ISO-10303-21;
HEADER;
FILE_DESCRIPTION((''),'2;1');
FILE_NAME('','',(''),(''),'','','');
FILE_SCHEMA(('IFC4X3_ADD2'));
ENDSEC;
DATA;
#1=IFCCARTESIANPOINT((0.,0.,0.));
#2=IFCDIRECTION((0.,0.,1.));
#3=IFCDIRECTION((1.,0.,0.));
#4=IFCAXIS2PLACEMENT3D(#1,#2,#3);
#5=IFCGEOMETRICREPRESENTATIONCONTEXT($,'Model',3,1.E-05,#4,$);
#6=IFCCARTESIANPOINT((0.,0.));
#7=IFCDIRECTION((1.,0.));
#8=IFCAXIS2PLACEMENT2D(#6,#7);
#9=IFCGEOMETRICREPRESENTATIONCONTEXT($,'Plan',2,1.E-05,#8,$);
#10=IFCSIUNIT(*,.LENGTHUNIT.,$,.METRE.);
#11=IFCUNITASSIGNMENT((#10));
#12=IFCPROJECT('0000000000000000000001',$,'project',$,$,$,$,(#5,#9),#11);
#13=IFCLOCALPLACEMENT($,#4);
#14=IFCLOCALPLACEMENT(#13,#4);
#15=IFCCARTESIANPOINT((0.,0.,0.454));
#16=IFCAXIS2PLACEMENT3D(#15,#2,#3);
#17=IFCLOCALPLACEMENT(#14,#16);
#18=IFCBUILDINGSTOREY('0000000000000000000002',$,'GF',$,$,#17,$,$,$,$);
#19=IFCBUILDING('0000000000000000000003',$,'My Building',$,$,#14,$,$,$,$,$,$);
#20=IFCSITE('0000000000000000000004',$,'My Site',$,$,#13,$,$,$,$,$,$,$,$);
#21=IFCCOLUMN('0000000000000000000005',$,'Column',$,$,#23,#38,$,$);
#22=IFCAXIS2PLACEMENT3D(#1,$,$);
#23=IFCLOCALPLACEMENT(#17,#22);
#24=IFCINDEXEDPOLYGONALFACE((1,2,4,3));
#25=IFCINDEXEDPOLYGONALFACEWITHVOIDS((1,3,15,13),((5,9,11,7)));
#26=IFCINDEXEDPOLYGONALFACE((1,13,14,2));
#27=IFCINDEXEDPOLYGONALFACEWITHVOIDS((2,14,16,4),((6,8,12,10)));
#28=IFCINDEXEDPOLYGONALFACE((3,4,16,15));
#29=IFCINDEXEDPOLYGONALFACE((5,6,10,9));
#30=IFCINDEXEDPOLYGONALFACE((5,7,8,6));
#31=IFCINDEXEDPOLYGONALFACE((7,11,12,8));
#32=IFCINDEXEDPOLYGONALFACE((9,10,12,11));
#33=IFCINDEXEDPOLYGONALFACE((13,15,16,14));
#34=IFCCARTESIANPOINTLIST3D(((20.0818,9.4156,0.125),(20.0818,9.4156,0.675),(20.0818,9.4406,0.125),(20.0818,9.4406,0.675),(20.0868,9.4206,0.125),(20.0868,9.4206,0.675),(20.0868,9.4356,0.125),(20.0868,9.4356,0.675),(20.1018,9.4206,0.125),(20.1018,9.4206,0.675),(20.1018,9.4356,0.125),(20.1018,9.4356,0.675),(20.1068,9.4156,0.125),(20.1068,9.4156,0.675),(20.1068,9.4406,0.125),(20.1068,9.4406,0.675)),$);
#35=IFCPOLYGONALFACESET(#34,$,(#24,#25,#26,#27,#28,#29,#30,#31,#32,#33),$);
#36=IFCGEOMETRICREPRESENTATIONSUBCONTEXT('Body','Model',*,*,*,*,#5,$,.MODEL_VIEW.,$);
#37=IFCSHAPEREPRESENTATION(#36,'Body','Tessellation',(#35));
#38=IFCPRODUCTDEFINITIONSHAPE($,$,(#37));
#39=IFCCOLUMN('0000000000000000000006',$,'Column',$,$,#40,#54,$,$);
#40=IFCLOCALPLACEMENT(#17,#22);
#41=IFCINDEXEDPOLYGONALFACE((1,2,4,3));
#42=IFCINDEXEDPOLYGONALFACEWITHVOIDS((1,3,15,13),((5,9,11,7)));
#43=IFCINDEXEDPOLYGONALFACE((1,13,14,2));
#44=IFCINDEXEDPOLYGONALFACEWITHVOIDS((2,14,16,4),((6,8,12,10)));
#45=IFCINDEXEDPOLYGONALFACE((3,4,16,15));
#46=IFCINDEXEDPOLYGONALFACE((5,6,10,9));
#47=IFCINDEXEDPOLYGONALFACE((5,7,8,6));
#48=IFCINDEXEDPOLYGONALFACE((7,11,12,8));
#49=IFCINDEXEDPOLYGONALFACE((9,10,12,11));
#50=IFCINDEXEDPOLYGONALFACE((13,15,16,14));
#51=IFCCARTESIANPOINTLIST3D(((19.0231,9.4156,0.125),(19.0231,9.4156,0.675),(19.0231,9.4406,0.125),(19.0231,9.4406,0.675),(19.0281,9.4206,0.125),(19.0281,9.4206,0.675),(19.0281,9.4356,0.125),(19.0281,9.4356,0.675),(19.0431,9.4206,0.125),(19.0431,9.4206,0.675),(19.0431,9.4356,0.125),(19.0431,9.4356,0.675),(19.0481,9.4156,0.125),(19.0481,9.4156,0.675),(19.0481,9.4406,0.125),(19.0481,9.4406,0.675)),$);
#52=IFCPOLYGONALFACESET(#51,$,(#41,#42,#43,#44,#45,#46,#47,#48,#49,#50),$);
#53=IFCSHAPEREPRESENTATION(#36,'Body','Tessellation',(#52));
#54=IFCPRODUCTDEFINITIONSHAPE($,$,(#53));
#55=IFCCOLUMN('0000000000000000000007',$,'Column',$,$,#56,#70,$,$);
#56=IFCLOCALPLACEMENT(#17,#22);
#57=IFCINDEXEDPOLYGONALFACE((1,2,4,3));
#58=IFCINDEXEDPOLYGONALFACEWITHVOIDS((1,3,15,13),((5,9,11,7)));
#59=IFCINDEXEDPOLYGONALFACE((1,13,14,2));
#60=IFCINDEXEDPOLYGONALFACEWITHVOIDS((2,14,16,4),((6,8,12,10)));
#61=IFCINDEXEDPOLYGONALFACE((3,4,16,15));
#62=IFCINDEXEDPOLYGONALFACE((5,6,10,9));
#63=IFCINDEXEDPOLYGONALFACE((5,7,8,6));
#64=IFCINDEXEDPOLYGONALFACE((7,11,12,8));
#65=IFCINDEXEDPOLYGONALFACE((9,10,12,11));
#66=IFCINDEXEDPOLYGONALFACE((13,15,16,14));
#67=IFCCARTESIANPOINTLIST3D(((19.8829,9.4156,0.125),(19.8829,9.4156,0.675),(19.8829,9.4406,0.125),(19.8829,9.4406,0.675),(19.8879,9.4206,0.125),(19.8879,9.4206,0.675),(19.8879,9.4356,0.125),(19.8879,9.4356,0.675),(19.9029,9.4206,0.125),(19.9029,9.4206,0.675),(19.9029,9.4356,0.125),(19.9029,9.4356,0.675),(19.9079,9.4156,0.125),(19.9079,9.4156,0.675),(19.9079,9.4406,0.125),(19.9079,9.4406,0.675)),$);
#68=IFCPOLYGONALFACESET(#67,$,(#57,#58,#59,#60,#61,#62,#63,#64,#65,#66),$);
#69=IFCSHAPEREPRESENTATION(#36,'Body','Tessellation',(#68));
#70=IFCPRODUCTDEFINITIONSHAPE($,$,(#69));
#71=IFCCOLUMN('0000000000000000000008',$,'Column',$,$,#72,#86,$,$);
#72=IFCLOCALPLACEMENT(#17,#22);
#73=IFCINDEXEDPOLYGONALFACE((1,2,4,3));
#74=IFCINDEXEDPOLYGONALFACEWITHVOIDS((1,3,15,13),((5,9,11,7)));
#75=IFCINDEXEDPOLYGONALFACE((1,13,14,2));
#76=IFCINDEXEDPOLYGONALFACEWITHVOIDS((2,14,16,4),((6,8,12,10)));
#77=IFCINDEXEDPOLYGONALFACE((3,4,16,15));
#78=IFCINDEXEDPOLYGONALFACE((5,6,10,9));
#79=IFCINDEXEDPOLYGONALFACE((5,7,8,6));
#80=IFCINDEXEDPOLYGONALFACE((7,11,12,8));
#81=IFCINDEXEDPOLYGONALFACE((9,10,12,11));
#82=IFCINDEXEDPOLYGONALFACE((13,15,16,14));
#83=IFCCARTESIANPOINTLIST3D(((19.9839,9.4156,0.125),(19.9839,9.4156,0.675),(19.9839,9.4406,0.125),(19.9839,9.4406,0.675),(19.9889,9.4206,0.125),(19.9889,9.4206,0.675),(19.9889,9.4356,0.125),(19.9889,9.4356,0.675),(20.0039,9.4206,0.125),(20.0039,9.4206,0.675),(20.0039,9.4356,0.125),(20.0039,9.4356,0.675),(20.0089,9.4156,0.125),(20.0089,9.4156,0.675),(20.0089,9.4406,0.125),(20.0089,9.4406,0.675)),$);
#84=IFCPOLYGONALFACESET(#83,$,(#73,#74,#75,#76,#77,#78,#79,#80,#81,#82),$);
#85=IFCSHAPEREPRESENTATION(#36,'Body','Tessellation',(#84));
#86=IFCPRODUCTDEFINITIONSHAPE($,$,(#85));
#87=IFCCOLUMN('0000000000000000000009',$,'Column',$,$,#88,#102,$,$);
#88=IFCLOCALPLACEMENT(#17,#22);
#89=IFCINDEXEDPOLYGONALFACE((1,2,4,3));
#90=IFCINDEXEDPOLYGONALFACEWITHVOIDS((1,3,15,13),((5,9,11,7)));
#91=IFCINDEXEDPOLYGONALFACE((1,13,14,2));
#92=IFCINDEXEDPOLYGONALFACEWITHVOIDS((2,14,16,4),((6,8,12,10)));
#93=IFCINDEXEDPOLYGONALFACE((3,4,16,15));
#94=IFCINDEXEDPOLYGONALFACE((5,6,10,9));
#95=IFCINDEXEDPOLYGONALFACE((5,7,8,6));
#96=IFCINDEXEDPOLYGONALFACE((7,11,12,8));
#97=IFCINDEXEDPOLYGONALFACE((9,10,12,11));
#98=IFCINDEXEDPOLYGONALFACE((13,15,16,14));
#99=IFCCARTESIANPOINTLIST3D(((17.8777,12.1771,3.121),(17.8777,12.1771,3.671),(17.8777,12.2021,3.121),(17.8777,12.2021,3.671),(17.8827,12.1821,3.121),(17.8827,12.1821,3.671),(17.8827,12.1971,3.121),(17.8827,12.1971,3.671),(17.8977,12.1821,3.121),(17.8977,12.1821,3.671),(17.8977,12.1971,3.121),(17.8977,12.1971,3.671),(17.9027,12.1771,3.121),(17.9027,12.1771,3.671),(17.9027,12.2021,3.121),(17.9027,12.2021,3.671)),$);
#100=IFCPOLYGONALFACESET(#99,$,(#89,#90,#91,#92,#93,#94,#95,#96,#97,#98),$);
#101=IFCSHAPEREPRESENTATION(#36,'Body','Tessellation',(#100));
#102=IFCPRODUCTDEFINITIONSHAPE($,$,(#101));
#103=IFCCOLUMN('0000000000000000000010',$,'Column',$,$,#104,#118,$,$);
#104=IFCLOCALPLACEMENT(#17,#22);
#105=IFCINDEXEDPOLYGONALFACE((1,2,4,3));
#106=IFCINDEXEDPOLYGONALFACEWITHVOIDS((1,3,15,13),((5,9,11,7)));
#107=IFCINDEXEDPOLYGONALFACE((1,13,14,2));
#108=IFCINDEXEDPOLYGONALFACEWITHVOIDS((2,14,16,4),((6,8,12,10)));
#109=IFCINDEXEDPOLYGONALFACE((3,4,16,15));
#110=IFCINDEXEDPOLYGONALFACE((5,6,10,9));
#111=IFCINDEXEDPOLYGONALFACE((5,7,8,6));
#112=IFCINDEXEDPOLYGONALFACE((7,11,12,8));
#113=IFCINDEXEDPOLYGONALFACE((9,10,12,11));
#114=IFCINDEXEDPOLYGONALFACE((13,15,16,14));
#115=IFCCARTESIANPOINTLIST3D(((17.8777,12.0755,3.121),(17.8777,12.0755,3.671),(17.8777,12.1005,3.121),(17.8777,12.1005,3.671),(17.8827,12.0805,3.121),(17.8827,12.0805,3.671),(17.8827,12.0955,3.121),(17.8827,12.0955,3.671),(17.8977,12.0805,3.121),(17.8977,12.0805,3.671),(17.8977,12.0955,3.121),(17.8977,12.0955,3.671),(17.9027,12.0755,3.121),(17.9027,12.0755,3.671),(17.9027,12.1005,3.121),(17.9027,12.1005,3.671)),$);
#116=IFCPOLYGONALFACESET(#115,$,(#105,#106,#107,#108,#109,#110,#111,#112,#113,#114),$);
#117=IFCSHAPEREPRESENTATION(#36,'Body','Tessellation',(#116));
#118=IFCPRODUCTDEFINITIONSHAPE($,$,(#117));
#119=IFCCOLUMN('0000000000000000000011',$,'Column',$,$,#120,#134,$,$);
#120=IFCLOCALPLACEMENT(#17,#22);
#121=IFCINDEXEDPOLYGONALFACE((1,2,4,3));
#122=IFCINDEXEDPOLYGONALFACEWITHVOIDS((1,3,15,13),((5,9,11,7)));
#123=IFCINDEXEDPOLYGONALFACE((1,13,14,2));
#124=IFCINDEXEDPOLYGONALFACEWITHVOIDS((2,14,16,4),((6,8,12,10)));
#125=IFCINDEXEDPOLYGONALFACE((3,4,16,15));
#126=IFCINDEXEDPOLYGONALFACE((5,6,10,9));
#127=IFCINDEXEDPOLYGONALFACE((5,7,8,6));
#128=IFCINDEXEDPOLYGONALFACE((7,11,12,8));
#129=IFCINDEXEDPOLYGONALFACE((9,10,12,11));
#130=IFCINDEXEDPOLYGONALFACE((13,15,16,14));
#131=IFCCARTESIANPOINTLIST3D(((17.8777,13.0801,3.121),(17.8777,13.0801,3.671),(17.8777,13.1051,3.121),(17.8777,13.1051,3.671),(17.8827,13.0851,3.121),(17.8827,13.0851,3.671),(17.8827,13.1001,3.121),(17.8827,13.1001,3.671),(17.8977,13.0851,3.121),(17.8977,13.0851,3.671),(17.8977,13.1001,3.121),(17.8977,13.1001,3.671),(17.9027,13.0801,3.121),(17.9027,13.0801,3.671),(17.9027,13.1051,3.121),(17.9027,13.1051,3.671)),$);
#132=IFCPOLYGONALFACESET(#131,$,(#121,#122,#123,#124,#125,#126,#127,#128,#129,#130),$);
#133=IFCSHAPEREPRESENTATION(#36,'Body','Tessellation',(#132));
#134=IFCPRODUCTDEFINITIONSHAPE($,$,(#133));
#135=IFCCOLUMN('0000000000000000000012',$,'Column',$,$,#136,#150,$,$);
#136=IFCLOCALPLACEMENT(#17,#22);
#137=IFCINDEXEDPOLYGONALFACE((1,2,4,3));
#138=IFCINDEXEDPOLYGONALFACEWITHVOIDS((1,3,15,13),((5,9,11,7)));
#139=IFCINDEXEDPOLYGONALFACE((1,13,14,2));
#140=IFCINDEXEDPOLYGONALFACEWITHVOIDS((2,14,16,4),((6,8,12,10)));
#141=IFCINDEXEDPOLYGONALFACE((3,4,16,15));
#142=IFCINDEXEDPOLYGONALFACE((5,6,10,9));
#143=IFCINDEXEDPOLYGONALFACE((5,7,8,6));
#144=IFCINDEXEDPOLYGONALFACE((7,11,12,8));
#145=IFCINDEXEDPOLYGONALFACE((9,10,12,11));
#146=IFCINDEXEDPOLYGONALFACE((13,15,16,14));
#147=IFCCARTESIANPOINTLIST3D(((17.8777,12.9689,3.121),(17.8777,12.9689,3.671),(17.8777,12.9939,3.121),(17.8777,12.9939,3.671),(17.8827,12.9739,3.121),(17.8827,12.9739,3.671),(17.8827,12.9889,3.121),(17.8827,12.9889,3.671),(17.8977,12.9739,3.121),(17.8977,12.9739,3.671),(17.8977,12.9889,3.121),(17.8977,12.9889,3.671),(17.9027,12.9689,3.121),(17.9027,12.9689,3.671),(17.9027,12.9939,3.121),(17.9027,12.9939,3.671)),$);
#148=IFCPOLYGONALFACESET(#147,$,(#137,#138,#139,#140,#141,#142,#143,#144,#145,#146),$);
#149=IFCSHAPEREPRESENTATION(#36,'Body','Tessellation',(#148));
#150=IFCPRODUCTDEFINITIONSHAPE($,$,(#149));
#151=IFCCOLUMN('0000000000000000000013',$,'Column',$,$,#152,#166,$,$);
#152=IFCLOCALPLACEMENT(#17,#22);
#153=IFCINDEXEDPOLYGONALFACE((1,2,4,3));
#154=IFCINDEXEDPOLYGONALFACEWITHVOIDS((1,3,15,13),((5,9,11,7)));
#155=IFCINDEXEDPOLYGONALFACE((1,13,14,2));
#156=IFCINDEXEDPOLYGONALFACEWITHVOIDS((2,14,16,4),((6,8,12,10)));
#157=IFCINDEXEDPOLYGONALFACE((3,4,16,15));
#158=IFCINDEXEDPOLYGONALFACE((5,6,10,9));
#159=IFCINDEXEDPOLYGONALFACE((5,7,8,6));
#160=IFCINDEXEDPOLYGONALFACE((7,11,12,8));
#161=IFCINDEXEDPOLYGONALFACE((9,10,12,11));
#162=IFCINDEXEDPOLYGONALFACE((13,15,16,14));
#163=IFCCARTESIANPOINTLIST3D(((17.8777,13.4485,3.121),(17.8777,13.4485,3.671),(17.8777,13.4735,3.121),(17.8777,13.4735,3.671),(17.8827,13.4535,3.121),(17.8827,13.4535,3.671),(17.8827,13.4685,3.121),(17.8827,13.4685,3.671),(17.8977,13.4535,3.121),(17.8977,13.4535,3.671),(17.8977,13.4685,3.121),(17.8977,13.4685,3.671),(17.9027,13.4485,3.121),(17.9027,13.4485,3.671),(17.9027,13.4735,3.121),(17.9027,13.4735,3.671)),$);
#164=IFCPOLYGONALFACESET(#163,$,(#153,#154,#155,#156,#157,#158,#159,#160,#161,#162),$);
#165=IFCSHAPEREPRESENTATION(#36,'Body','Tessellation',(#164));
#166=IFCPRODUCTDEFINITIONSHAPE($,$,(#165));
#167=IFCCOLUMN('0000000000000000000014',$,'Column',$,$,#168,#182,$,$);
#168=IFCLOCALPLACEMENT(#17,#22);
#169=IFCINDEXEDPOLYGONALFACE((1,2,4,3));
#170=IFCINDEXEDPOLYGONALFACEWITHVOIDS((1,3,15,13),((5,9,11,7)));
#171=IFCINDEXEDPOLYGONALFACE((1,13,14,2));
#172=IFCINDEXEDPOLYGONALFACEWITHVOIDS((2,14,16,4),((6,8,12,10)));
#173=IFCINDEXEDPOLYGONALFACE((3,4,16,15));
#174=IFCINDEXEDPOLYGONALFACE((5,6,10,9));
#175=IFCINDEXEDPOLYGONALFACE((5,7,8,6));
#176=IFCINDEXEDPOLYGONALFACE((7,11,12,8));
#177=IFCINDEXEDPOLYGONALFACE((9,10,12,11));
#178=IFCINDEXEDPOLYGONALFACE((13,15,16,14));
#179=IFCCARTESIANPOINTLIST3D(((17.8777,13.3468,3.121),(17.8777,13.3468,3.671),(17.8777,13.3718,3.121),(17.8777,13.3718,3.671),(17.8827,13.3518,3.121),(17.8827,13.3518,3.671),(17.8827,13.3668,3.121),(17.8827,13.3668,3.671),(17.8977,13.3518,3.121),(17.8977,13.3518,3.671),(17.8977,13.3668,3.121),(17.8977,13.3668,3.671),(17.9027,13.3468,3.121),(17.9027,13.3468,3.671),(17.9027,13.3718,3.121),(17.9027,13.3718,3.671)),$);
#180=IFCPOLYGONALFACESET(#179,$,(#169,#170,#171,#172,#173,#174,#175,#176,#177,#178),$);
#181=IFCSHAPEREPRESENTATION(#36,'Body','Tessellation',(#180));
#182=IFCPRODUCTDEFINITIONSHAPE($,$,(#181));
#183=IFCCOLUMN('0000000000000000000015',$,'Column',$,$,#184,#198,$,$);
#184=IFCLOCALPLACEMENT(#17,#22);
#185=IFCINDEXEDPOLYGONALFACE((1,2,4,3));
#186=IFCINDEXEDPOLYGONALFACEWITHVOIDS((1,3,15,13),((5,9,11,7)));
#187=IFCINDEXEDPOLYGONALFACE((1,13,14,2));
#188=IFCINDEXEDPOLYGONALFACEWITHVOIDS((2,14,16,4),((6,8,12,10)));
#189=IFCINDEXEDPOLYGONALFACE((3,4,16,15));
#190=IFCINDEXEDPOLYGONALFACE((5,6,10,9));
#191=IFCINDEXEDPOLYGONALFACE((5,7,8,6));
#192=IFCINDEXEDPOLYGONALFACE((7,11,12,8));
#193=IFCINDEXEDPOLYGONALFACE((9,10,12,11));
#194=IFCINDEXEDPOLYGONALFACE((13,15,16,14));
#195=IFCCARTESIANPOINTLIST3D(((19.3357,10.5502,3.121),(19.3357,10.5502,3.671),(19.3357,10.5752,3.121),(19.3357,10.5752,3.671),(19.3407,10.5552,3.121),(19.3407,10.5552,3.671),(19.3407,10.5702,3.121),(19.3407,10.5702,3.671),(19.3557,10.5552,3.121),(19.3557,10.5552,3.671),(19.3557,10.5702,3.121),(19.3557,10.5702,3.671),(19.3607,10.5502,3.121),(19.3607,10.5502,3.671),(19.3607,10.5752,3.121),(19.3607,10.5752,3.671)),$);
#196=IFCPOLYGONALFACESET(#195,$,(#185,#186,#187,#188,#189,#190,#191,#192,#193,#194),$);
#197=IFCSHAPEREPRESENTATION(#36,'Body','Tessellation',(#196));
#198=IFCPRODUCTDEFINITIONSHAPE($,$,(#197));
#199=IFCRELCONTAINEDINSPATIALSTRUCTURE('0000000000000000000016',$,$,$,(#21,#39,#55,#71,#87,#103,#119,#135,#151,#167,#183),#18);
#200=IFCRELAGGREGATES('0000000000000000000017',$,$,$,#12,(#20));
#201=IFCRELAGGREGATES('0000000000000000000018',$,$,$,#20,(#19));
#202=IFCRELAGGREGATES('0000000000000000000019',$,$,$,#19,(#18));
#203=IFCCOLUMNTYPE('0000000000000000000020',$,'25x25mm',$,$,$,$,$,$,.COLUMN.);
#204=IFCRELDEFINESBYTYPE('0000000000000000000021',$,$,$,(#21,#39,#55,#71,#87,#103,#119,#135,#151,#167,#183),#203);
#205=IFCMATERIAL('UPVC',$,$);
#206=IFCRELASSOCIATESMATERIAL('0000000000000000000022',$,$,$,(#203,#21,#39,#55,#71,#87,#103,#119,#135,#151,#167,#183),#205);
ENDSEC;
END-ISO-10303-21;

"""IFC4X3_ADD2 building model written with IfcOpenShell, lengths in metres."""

from ifc_helpers import new_model, si_unit, frame, origin_with_axes, origin_2d_with_axis, place, context, subcontext, project, spatial, hollow_rectangle, extrude, material, material_profile, profile_set, profile_usage, type_object, element, save


model = new_model("IFC4X3_ADD2")

# Units and contexts
model_context = context("Model", 3, precision=1e-05, world=origin_with_axes())
plan_context = context("Plan", 2, precision=1e-05, world=origin_2d_with_axis())
body_context = subcontext(model_context, "Body", "Model", "MODEL_VIEW")
ifc_project = project(units=[si_unit("LENGTHUNIT", "METRE")], contexts=[model_context, plan_context])

# Site, building, storey
site_placement = place(None, origin_with_axes())
site = spatial("IfcSite", under=ifc_project, at=site_placement, Name="My Site")
building_placement = place(site_placement, origin_with_axes())
building = spatial("IfcBuilding", under=site, at=building_placement, Name="My Building")
storey_placement = place(building_placement, frame((0.0, 0.0, 0.454), z_axis=(0.0, 0.0, 1.0), x_axis=(1.0, 0.0, 0.0)))
storey = spatial("IfcBuildingStorey", under=building, at=storey_placement, Name="GF")

# Columns
ifc_material = material(Name="UPVC")
ifc_material_profile_1 = material_profile(ifc_material, hollow_rectangle(XDim=0.025, YDim=0.025, WallThickness=0.005))
ifc_profile_set_1 = profile_set([ifc_material_profile_1])
column_type_1 = type_object("IfcColumnType", Name="25x25mm", PredefinedType="COLUMN", material=ifc_profile_set_1)
ifc_profile_usage_1 = profile_usage(ifc_profile_set_1)
column_1_placement = place(storey_placement, frame((20.0943, 9.4281, 0.125), z_axis=(0.0, 0.0, 1.0), x_axis=(0.0, -1.0, 0.0)))
element("IfcColumn", 1, at=column_1_placement, inside=storey, type_object=column_type_1, material=ifc_profile_usage_1, Name="Column", context=body_context, shape_type="SweptSolid", body=[
    extrude(hollow_rectangle(XDim=0.025, YDim=0.025, WallThickness=0.005), origin_with_axes(), (0.0, 0.0, 1.0), 0.55),
])
ifc_profile_usage_2 = profile_usage(ifc_profile_set_1)
column_2_placement = place(storey_placement, frame((19.0356, 9.4281, 0.125), z_axis=(0.0, 0.0, 1.0), x_axis=(0.0, -1.0, 0.0)))
element("IfcColumn", 2, at=column_2_placement, inside=storey, type_object=column_type_1, material=ifc_profile_usage_2, Name="Column", context=body_context, shape_type="SweptSolid", body=[
    extrude(hollow_rectangle(XDim=0.025, YDim=0.025, WallThickness=0.005), origin_with_axes(), (0.0, 0.0, 1.0), 0.55),
])
ifc_profile_usage_3 = profile_usage(ifc_profile_set_1)
column_3_placement = place(storey_placement, frame((19.8954, 9.4281, 0.125), z_axis=(0.0, 0.0, 1.0), x_axis=(0.0, -1.0, 0.0)))
element("IfcColumn", 3, at=column_3_placement, inside=storey, type_object=column_type_1, material=ifc_profile_usage_3, Name="Column", context=body_context, shape_type="SweptSolid", body=[
    extrude(hollow_rectangle(XDim=0.025, YDim=0.025, WallThickness=0.005), origin_with_axes(), (0.0, 0.0, 1.0), 0.55),
])
ifc_profile_usage_4 = profile_usage(ifc_profile_set_1)
column_4_placement = place(storey_placement, frame((19.9964, 9.4281, 0.125), z_axis=(0.0, 0.0, 1.0), x_axis=(0.0, -1.0, 0.0)))
element("IfcColumn", 4, at=column_4_placement, inside=storey, type_object=column_type_1, material=ifc_profile_usage_4, Name="Column", context=body_context, shape_type="SweptSolid", body=[
    extrude(hollow_rectangle(XDim=0.025, YDim=0.025, WallThickness=0.005), origin_with_axes(), (0.0, 0.0, 1.0), 0.55),
])
ifc_profile_usage_5 = profile_usage(ifc_profile_set_1)
column_5_placement = place(storey_placement, frame((17.8902, 12.1896, 3.121), z_axis=(0.0, 0.0, 1.0), x_axis=(0.0, -1.0, 0.0)))
element("IfcColumn", 5, at=column_5_placement, inside=storey, type_object=column_type_1, material=ifc_profile_usage_5, Name="Column", context=body_context, shape_type="SweptSolid", body=[
    extrude(hollow_rectangle(XDim=0.025, YDim=0.025, WallThickness=0.005), origin_with_axes(), (0.0, 0.0, 1.0), 0.55),
])
ifc_profile_usage_6 = profile_usage(ifc_profile_set_1)
column_6_placement = place(storey_placement, frame((17.8902, 12.088, 3.121), z_axis=(0.0, 0.0, 1.0), x_axis=(0.0, -1.0, 0.0)))
element("IfcColumn", 6, at=column_6_placement, inside=storey, type_object=column_type_1, material=ifc_profile_usage_6, Name="Column", context=body_context, shape_type="SweptSolid", body=[
    extrude(hollow_rectangle(XDim=0.025, YDim=0.025, WallThickness=0.005), origin_with_axes(), (0.0, 0.0, 1.0), 0.55),
])
ifc_profile_usage_7 = profile_usage(ifc_profile_set_1)
column_7_placement = place(storey_placement, frame((17.8902, 13.0926, 3.121), z_axis=(0.0, 0.0, 1.0), x_axis=(0.0, -1.0, 0.0)))
element("IfcColumn", 7, at=column_7_placement, inside=storey, type_object=column_type_1, material=ifc_profile_usage_7, Name="Column", context=body_context, shape_type="SweptSolid", body=[
    extrude(hollow_rectangle(XDim=0.025, YDim=0.025, WallThickness=0.005), origin_with_axes(), (0.0, 0.0, 1.0), 0.55),
])
ifc_profile_usage_8 = profile_usage(ifc_profile_set_1)
column_8_placement = place(storey_placement, frame((17.8902, 12.9814, 3.121), z_axis=(0.0, 0.0, 1.0), x_axis=(0.0, -1.0, 0.0)))
element("IfcColumn", 8, at=column_8_placement, inside=storey, type_object=column_type_1, material=ifc_profile_usage_8, Name="Column", context=body_context, shape_type="SweptSolid", body=[
    extrude(hollow_rectangle(XDim=0.025, YDim=0.025, WallThickness=0.005), origin_with_axes(), (0.0, 0.0, 1.0), 0.55),
])
ifc_profile_usage_9 = profile_usage(ifc_profile_set_1)
column_9_placement = place(storey_placement, frame((17.8902, 13.461, 3.121), z_axis=(0.0, 0.0, 1.0), x_axis=(0.0, -1.0, 0.0)))
element("IfcColumn", 9, at=column_9_placement, inside=storey, type_object=column_type_1, material=ifc_profile_usage_9, Name="Column", context=body_context, shape_type="SweptSolid", body=[
    extrude(hollow_rectangle(XDim=0.025, YDim=0.025, WallThickness=0.005), origin_with_axes(), (0.0, 0.0, 1.0), 0.55),
])
ifc_profile_usage_10 = profile_usage(ifc_profile_set_1)
column_10_placement = place(storey_placement, frame((17.8902, 13.3593, 3.121), z_axis=(0.0, 0.0, 1.0), x_axis=(0.0, -1.0, 0.0)))
element("IfcColumn", 10, at=column_10_placement, inside=storey, type_object=column_type_1, material=ifc_profile_usage_10, Name="Column", context=body_context, shape_type="SweptSolid", body=[
    extrude(hollow_rectangle(XDim=0.025, YDim=0.025, WallThickness=0.005), origin_with_axes(), (0.0, 0.0, 1.0), 0.55),
])
ifc_profile_usage_11 = profile_usage(ifc_profile_set_1)
column_11_placement = place(storey_placement, frame((19.3482, 10.5627, 3.121), z_axis=(0.0, 0.0, 1.0), x_axis=(0.0, -1.0, 0.0)))
element("IfcColumn", 11, at=column_11_placement, inside=storey, type_object=column_type_1, material=ifc_profile_usage_11, Name="Column", context=body_context, shape_type="SweptSolid", body=[
    extrude(hollow_rectangle(XDim=0.025, YDim=0.025, WallThickness=0.005), origin_with_axes(), (0.0, 0.0, 1.0), 0.55),
])

save(model, "model.ifc")
